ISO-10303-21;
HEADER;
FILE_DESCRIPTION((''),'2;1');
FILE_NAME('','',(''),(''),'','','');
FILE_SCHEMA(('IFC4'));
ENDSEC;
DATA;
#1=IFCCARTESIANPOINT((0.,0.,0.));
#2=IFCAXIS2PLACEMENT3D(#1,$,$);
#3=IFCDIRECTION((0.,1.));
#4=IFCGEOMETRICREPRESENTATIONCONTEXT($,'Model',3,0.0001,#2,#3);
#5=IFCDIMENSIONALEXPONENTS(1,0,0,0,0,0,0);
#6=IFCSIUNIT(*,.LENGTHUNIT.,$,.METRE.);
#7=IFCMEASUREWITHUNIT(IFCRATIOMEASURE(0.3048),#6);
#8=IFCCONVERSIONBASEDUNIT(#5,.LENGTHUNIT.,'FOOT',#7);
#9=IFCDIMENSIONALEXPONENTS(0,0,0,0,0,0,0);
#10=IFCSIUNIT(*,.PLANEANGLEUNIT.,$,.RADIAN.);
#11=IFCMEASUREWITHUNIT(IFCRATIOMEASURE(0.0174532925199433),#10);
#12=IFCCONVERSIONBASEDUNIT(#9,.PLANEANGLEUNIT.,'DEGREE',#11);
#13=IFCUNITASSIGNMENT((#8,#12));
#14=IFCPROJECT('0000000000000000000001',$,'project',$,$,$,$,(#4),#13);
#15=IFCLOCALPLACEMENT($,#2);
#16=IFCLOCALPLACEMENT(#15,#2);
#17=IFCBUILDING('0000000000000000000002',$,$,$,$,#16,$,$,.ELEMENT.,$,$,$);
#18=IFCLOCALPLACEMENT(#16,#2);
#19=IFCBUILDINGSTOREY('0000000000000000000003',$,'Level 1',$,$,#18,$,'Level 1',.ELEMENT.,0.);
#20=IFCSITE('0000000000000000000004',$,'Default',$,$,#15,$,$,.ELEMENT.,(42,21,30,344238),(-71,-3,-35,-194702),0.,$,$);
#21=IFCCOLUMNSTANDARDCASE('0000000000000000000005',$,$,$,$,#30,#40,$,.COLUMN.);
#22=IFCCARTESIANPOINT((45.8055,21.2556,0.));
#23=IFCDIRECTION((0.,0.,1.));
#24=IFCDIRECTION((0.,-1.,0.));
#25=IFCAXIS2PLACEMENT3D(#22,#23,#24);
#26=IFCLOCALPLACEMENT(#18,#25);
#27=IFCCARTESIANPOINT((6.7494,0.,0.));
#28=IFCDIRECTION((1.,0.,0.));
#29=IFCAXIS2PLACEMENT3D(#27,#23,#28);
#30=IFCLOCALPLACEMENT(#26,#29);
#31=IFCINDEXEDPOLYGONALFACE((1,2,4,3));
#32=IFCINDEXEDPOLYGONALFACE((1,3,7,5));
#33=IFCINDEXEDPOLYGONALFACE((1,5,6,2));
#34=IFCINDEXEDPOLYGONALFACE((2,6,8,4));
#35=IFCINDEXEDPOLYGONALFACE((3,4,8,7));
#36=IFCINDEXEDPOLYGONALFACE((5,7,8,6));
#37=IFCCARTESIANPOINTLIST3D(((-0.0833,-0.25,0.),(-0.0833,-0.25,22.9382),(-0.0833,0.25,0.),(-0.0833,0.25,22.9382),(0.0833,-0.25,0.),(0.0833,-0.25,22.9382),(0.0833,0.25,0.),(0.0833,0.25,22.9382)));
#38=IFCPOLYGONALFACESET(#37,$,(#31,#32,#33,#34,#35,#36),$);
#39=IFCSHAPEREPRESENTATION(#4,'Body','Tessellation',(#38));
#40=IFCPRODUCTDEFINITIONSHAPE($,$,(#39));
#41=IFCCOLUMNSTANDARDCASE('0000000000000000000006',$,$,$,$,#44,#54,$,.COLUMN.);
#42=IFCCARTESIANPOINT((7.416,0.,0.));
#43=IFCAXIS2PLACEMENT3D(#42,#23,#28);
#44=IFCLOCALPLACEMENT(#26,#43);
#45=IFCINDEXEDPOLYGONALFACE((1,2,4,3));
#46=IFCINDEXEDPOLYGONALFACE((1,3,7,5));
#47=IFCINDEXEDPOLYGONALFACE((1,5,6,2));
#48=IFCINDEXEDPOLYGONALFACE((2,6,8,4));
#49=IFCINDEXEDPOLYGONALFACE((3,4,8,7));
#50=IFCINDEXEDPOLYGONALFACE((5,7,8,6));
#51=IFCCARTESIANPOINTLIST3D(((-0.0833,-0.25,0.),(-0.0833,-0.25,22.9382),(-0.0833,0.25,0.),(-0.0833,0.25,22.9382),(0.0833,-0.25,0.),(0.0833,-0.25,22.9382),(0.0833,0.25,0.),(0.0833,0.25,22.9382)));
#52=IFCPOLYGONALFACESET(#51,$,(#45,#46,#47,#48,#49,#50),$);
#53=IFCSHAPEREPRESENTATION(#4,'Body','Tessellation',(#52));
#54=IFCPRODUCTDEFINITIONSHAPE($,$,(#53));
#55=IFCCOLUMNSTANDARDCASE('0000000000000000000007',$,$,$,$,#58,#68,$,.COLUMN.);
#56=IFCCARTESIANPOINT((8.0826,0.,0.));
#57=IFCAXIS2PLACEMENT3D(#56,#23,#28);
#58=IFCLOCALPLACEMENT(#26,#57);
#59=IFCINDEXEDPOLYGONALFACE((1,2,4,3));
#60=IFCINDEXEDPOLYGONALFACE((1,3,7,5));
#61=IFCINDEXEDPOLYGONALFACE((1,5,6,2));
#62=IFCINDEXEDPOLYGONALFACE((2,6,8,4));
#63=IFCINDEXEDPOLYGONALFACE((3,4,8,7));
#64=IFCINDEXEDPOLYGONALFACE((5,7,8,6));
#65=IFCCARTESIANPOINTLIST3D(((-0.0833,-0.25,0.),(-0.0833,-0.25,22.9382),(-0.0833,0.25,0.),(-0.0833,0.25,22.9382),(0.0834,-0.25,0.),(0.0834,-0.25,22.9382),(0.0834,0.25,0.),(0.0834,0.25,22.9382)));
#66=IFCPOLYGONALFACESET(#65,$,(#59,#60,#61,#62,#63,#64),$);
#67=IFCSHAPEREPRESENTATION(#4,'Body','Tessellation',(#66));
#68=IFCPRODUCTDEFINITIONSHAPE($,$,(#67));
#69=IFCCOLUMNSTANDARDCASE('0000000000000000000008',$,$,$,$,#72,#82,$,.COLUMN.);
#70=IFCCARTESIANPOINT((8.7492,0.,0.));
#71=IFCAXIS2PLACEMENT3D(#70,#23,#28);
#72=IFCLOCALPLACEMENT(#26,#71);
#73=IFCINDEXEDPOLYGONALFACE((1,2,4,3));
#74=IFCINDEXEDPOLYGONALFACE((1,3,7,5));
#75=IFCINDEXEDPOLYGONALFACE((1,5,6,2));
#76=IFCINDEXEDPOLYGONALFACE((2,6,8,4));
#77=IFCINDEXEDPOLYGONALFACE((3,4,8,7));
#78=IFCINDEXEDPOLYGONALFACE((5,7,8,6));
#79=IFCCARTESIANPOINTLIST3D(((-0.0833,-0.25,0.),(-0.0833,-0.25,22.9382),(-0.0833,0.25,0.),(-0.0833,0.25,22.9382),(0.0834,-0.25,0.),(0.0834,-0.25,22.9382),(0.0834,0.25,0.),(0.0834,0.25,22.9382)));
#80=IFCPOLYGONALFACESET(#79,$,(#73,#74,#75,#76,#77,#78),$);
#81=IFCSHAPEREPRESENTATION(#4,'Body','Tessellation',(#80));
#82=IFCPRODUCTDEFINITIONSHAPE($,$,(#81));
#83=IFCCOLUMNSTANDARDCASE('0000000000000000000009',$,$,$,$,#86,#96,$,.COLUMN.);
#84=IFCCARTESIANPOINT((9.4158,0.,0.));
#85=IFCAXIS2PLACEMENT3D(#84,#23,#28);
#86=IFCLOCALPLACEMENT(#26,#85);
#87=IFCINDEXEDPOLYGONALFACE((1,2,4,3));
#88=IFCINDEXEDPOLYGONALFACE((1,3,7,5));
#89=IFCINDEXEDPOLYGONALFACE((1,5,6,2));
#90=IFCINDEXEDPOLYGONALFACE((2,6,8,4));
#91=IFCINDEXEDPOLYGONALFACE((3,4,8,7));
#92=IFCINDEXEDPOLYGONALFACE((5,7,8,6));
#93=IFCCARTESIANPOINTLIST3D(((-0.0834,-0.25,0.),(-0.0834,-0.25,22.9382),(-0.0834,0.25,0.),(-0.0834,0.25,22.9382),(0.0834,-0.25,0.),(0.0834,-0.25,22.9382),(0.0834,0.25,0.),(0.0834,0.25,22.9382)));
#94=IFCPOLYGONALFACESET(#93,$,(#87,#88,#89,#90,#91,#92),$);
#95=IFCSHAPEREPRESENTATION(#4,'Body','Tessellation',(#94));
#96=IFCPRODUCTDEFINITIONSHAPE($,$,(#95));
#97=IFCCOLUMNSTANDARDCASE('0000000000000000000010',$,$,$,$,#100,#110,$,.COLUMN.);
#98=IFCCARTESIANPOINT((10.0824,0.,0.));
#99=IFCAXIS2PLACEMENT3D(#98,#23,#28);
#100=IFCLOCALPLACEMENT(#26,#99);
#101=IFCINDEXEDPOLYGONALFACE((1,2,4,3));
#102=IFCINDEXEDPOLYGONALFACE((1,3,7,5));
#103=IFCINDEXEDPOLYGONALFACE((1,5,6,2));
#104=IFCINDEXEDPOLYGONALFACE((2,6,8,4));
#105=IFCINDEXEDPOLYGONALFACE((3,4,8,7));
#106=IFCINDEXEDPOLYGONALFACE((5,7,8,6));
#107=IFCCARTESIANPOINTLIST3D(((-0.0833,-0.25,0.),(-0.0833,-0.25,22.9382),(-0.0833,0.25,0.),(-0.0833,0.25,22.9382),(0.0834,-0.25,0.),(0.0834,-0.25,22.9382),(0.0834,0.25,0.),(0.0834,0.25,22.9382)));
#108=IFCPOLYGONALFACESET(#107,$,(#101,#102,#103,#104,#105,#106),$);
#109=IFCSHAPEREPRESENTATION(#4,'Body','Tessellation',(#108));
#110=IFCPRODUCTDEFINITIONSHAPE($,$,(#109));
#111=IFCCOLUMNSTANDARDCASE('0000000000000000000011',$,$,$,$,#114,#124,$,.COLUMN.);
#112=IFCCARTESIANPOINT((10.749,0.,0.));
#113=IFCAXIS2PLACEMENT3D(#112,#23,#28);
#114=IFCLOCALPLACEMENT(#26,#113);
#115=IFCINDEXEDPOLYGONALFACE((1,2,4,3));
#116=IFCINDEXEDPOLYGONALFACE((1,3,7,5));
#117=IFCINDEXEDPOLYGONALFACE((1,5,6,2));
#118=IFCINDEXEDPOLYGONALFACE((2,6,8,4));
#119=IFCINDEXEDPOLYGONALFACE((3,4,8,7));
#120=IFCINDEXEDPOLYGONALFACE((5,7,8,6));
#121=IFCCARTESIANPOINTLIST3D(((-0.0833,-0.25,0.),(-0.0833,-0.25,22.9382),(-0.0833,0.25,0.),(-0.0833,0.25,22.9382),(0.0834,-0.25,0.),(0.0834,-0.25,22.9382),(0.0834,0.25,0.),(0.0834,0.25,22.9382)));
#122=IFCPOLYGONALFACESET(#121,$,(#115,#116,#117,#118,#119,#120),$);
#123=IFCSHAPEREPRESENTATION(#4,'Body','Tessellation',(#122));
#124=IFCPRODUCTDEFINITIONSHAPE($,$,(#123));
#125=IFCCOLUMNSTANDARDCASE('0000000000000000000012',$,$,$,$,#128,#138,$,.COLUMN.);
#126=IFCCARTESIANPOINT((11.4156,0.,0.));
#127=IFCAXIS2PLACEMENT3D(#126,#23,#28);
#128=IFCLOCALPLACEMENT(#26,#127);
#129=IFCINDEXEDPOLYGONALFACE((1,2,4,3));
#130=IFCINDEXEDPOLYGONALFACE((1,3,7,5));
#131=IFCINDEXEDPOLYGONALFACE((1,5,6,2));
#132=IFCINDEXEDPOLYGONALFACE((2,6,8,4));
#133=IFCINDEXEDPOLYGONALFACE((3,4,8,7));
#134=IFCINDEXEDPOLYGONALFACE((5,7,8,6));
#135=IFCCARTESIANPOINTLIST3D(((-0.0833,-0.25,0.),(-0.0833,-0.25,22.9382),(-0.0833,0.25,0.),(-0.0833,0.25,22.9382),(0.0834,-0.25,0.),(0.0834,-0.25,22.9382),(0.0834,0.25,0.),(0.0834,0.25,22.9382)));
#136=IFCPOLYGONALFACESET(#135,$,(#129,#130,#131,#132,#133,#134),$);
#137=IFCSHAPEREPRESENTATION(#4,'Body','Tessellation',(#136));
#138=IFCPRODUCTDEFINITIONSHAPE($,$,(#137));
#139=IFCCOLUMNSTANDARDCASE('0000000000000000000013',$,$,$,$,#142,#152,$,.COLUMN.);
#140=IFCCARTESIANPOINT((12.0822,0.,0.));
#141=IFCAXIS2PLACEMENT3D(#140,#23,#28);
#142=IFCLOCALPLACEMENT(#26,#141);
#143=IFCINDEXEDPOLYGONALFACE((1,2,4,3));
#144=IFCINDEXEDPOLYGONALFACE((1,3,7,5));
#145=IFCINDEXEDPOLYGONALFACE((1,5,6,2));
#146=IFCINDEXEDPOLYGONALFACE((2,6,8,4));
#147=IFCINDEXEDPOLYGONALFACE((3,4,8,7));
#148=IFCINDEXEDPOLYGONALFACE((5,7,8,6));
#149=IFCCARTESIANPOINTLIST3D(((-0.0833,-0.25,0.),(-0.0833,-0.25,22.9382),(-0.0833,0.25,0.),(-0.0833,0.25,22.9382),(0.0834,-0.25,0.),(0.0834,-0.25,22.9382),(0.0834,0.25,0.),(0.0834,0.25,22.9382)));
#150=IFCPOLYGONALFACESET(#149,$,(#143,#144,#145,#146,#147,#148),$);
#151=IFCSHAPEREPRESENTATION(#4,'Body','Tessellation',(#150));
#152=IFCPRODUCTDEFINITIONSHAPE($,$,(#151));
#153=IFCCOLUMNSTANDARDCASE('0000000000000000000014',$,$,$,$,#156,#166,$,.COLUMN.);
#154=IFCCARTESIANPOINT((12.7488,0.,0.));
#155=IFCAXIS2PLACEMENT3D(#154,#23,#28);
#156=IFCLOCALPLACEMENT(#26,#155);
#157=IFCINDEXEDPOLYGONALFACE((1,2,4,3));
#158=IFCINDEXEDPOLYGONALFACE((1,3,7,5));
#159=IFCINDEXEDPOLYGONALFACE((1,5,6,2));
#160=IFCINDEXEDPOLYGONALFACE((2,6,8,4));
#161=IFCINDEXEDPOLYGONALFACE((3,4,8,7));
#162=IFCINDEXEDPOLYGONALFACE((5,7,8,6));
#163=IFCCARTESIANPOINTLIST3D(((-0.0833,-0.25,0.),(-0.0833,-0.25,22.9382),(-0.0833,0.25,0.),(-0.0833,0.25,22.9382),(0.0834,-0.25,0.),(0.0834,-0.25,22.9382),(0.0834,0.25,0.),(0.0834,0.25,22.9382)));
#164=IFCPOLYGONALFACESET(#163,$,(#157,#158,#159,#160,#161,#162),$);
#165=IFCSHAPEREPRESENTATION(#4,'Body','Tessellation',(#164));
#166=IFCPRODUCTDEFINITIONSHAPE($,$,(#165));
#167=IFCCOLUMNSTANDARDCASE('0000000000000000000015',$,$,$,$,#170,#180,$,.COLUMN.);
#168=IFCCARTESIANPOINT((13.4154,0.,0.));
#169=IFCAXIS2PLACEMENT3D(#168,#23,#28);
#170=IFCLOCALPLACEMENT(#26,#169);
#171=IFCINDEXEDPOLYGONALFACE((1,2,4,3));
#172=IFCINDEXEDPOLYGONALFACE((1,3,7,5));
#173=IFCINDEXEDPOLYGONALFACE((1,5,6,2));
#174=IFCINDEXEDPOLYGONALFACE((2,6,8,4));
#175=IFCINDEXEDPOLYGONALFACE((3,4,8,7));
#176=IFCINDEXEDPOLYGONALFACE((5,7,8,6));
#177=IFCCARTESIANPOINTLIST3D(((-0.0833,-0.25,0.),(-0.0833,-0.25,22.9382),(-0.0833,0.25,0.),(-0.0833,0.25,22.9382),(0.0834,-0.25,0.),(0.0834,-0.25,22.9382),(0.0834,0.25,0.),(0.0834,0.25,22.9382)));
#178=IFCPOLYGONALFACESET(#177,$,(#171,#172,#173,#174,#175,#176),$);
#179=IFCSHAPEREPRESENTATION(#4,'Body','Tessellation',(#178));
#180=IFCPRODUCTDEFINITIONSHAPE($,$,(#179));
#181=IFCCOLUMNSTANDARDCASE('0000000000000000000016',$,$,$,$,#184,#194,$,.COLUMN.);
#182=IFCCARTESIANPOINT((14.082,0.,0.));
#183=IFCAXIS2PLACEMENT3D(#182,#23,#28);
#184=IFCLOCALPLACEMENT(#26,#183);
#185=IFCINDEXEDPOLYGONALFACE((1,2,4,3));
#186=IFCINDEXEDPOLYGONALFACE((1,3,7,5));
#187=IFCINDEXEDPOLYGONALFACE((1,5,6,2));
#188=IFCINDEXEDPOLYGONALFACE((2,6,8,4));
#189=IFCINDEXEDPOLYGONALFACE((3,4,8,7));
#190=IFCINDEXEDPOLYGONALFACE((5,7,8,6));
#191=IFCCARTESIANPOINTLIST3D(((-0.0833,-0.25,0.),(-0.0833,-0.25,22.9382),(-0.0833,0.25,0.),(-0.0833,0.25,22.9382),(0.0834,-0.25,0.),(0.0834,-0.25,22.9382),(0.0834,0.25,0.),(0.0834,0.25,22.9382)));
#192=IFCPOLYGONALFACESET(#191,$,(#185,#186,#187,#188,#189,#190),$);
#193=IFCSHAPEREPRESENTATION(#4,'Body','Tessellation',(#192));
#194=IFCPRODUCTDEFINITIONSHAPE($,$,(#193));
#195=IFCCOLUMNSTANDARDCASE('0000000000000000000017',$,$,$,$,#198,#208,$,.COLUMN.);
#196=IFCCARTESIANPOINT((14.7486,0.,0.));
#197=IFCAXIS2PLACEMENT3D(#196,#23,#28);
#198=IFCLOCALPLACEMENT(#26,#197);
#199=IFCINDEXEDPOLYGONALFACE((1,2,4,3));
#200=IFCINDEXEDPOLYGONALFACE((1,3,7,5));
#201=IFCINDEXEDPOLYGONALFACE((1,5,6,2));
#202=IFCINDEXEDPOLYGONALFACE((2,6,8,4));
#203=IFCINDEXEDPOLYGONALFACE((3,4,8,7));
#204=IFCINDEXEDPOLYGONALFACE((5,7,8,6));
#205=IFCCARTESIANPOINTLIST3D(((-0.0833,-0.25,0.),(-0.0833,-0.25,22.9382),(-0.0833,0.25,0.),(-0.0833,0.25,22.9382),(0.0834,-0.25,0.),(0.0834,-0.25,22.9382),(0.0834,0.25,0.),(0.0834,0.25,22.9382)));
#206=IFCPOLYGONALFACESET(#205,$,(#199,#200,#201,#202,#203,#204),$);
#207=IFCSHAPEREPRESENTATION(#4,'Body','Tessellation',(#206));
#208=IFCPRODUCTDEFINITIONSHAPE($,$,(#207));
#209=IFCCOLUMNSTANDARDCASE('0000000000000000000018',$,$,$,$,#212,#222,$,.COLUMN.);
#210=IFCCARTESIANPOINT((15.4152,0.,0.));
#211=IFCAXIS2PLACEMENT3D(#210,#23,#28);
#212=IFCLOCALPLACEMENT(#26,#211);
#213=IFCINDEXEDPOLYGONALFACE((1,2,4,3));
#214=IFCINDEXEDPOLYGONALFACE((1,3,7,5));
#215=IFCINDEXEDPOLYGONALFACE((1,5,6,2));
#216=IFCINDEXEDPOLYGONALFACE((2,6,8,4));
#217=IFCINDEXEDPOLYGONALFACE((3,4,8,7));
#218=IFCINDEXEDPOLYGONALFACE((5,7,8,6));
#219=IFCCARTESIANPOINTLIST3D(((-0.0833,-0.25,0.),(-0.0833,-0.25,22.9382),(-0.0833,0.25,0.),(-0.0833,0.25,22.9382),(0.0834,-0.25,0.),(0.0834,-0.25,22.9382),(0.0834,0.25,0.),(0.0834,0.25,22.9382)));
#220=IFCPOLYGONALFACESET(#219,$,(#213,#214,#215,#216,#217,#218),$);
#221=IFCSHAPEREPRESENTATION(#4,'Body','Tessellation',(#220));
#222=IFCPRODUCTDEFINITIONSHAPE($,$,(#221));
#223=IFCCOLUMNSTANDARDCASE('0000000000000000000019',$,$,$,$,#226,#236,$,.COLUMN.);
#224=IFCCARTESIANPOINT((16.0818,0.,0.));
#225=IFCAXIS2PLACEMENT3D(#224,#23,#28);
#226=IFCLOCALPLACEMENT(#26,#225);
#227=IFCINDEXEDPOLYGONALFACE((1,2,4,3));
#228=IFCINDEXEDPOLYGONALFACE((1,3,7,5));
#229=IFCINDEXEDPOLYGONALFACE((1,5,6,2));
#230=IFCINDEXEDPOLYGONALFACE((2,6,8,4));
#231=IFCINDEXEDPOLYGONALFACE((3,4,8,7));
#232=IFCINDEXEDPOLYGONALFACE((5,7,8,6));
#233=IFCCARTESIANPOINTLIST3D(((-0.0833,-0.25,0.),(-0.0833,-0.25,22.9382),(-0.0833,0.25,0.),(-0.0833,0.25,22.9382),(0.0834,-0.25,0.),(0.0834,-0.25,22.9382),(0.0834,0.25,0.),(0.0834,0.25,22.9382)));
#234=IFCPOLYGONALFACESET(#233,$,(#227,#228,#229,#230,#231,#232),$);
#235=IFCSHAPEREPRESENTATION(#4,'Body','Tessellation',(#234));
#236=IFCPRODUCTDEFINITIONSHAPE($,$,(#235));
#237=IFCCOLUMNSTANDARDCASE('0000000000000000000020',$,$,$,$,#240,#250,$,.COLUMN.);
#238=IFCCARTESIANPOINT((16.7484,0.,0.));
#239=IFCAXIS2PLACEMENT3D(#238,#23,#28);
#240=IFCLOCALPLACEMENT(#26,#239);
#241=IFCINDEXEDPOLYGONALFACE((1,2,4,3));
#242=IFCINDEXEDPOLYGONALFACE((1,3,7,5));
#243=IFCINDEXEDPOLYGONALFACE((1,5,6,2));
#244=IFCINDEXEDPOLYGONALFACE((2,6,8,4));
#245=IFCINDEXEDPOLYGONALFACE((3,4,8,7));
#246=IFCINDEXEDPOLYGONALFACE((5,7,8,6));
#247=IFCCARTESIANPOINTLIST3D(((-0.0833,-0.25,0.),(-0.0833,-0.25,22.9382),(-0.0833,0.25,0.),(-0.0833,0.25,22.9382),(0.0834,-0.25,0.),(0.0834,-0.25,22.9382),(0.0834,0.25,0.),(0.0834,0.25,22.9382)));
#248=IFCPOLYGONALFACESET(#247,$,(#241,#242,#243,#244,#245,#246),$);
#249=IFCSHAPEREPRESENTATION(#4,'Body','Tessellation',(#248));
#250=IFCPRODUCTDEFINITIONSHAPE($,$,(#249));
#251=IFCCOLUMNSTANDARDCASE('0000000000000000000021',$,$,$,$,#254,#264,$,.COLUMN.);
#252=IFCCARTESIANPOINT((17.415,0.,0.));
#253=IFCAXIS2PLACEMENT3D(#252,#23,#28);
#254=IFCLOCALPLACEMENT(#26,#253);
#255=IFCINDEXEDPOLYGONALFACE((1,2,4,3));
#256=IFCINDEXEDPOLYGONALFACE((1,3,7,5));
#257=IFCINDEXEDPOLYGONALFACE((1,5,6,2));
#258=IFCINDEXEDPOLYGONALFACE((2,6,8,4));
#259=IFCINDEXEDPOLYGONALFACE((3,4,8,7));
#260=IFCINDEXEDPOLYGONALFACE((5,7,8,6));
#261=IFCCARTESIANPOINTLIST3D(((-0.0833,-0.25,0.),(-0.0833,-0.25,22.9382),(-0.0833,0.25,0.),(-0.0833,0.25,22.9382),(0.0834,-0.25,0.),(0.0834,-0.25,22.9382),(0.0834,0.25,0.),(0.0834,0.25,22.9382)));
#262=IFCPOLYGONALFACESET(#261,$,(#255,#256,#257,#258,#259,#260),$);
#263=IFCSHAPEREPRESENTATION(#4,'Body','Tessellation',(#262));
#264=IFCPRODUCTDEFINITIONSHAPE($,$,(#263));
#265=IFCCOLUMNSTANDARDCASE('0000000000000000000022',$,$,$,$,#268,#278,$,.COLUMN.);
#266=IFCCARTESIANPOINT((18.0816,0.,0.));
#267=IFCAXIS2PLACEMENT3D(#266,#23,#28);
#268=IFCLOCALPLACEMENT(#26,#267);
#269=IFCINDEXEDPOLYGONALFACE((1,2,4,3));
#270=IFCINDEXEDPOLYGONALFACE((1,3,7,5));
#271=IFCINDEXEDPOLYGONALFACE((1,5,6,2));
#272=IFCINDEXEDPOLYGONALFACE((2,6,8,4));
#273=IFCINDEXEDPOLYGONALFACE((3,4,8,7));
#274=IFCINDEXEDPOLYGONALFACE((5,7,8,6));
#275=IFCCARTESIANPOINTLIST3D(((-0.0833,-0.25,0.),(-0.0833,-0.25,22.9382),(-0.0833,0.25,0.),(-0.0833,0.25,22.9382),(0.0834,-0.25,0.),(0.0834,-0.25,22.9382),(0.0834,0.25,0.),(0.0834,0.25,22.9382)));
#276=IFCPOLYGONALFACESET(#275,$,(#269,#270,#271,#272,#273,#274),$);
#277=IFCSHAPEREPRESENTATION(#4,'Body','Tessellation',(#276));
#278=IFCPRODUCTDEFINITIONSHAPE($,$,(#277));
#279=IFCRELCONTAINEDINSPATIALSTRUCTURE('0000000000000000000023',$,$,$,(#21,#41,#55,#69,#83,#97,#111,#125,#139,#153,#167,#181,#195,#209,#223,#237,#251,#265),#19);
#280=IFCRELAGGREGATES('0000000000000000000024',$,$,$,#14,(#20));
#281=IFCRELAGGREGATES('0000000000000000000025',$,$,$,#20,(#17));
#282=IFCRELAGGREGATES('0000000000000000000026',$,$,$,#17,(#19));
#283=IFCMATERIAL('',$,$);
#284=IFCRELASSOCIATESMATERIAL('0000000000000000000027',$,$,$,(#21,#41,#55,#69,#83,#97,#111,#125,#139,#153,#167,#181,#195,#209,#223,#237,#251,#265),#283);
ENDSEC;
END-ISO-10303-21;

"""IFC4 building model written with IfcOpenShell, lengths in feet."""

from ifc_helpers import new_model, entity, si_unit, converted_unit, direction, frame, origin, place, context, project, spatial, rectangle, extrude, material, element, save


model = new_model("IFC4")

# Units and contexts
model_context = context("Model", 3, precision=0.0001, world=origin(), true_north=direction((0.0, 1.0)))
ifc_project = project(units=[converted_unit("LENGTHUNIT", "FOOT", entity("IfcRatioMeasure", 0.3048), si_unit("LENGTHUNIT", "METRE"), dimensions=[1, 0, 0, 0, 0, 0, 0]), converted_unit("PLANEANGLEUNIT", "DEGREE", entity("IfcRatioMeasure", 0.0174532925199433), si_unit("PLANEANGLEUNIT", "RADIAN"), dimensions=[0, 0, 0, 0, 0, 0, 0])], contexts=[model_context])

# Site, building, storey
site_placement = place(None, origin())
site = spatial("IfcSite", under=ifc_project, at=site_placement, Name="Default", CompositionType="ELEMENT", RefLatitude=(42, 21, 30, 344238), RefLongitude=(-71, -3, -35, -194702), RefElevation=0.0)
building_placement = place(site_placement, origin())
building = spatial("IfcBuilding", under=site, at=building_placement, CompositionType="ELEMENT")
storey_placement = place(building_placement, origin())
storey = spatial("IfcBuildingStorey", under=building, at=storey_placement, Name="Level 1", LongName="Level 1", CompositionType="ELEMENT", Elevation=0.0)

# Columns
ifc_material = material(Name="")
placement = place(storey_placement, frame((45.8055, 21.2556, 0.0), z_axis=(0.0, 0.0, 1.0), x_axis=(0.0, -1.0, 0.0)))
for number, where, z_axis, x_axis in (
    (1, (6.7494, 0.0, 0.0), (0.0, 0.0, 1.0), (1.0, 0.0, 0.0)),
    (2, (7.416, 0.0, 0.0), (0.0, 0.0, 1.0), (1.0, 0.0, 0.0)),
    (3, (8.0826, 0.0, 0.0), (0.0, 0.0, 1.0), (1.0, 0.0, 0.0)),
    (4, (8.7492, 0.0, 0.0), (0.0, 0.0, 1.0), (1.0, 0.0, 0.0)),
    (5, (9.4158, 0.0, 0.0), (0.0, 0.0, 1.0), (1.0, 0.0, 0.0)),
    (6, (10.0824, 0.0, 0.0), (0.0, 0.0, 1.0), (1.0, 0.0, 0.0)),
    (7, (10.749, 0.0, 0.0), (0.0, 0.0, 1.0), (1.0, 0.0, 0.0)),
    (8, (11.4156, 0.0, 0.0), (0.0, 0.0, 1.0), (1.0, 0.0, 0.0)),
    (9, (12.0822, 0.0, 0.0), (0.0, 0.0, 1.0), (1.0, 0.0, 0.0)),
    (10, (12.7488, 0.0, 0.0), (0.0, 0.0, 1.0), (1.0, 0.0, 0.0)),
    (11, (13.4154, 0.0, 0.0), (0.0, 0.0, 1.0), (1.0, 0.0, 0.0)),
    (12, (14.082, 0.0, 0.0), (0.0, 0.0, 1.0), (1.0, 0.0, 0.0)),
    (13, (14.7486, 0.0, 0.0), (0.0, 0.0, 1.0), (1.0, 0.0, 0.0)),
    (14, (15.4152, 0.0, 0.0), (0.0, 0.0, 1.0), (1.0, 0.0, 0.0)),
    (15, (16.0818, 0.0, 0.0), (0.0, 0.0, 1.0), (1.0, 0.0, 0.0)),
    (16, (16.7484, 0.0, 0.0), (0.0, 0.0, 1.0), (1.0, 0.0, 0.0)),
    (17, (17.415, 0.0, 0.0), (0.0, 0.0, 1.0), (1.0, 0.0, 0.0)),
    (18, (18.0816, 0.0, 0.0), (0.0, 0.0, 1.0), (1.0, 0.0, 0.0)),
):
    element("IfcColumnStandardCase", number, at=place(placement, frame(where, z_axis=z_axis, x_axis=x_axis)), inside=storey, material=ifc_material, PredefinedType="COLUMN", context=model_context, shape_type="SweptSolid", body=[
        extrude(rectangle(XDim=0.1667, YDim=0.5), origin(), (0.0, 0.0, 1.0), 22.9382),
    ])

save(model, "model.ifc")
